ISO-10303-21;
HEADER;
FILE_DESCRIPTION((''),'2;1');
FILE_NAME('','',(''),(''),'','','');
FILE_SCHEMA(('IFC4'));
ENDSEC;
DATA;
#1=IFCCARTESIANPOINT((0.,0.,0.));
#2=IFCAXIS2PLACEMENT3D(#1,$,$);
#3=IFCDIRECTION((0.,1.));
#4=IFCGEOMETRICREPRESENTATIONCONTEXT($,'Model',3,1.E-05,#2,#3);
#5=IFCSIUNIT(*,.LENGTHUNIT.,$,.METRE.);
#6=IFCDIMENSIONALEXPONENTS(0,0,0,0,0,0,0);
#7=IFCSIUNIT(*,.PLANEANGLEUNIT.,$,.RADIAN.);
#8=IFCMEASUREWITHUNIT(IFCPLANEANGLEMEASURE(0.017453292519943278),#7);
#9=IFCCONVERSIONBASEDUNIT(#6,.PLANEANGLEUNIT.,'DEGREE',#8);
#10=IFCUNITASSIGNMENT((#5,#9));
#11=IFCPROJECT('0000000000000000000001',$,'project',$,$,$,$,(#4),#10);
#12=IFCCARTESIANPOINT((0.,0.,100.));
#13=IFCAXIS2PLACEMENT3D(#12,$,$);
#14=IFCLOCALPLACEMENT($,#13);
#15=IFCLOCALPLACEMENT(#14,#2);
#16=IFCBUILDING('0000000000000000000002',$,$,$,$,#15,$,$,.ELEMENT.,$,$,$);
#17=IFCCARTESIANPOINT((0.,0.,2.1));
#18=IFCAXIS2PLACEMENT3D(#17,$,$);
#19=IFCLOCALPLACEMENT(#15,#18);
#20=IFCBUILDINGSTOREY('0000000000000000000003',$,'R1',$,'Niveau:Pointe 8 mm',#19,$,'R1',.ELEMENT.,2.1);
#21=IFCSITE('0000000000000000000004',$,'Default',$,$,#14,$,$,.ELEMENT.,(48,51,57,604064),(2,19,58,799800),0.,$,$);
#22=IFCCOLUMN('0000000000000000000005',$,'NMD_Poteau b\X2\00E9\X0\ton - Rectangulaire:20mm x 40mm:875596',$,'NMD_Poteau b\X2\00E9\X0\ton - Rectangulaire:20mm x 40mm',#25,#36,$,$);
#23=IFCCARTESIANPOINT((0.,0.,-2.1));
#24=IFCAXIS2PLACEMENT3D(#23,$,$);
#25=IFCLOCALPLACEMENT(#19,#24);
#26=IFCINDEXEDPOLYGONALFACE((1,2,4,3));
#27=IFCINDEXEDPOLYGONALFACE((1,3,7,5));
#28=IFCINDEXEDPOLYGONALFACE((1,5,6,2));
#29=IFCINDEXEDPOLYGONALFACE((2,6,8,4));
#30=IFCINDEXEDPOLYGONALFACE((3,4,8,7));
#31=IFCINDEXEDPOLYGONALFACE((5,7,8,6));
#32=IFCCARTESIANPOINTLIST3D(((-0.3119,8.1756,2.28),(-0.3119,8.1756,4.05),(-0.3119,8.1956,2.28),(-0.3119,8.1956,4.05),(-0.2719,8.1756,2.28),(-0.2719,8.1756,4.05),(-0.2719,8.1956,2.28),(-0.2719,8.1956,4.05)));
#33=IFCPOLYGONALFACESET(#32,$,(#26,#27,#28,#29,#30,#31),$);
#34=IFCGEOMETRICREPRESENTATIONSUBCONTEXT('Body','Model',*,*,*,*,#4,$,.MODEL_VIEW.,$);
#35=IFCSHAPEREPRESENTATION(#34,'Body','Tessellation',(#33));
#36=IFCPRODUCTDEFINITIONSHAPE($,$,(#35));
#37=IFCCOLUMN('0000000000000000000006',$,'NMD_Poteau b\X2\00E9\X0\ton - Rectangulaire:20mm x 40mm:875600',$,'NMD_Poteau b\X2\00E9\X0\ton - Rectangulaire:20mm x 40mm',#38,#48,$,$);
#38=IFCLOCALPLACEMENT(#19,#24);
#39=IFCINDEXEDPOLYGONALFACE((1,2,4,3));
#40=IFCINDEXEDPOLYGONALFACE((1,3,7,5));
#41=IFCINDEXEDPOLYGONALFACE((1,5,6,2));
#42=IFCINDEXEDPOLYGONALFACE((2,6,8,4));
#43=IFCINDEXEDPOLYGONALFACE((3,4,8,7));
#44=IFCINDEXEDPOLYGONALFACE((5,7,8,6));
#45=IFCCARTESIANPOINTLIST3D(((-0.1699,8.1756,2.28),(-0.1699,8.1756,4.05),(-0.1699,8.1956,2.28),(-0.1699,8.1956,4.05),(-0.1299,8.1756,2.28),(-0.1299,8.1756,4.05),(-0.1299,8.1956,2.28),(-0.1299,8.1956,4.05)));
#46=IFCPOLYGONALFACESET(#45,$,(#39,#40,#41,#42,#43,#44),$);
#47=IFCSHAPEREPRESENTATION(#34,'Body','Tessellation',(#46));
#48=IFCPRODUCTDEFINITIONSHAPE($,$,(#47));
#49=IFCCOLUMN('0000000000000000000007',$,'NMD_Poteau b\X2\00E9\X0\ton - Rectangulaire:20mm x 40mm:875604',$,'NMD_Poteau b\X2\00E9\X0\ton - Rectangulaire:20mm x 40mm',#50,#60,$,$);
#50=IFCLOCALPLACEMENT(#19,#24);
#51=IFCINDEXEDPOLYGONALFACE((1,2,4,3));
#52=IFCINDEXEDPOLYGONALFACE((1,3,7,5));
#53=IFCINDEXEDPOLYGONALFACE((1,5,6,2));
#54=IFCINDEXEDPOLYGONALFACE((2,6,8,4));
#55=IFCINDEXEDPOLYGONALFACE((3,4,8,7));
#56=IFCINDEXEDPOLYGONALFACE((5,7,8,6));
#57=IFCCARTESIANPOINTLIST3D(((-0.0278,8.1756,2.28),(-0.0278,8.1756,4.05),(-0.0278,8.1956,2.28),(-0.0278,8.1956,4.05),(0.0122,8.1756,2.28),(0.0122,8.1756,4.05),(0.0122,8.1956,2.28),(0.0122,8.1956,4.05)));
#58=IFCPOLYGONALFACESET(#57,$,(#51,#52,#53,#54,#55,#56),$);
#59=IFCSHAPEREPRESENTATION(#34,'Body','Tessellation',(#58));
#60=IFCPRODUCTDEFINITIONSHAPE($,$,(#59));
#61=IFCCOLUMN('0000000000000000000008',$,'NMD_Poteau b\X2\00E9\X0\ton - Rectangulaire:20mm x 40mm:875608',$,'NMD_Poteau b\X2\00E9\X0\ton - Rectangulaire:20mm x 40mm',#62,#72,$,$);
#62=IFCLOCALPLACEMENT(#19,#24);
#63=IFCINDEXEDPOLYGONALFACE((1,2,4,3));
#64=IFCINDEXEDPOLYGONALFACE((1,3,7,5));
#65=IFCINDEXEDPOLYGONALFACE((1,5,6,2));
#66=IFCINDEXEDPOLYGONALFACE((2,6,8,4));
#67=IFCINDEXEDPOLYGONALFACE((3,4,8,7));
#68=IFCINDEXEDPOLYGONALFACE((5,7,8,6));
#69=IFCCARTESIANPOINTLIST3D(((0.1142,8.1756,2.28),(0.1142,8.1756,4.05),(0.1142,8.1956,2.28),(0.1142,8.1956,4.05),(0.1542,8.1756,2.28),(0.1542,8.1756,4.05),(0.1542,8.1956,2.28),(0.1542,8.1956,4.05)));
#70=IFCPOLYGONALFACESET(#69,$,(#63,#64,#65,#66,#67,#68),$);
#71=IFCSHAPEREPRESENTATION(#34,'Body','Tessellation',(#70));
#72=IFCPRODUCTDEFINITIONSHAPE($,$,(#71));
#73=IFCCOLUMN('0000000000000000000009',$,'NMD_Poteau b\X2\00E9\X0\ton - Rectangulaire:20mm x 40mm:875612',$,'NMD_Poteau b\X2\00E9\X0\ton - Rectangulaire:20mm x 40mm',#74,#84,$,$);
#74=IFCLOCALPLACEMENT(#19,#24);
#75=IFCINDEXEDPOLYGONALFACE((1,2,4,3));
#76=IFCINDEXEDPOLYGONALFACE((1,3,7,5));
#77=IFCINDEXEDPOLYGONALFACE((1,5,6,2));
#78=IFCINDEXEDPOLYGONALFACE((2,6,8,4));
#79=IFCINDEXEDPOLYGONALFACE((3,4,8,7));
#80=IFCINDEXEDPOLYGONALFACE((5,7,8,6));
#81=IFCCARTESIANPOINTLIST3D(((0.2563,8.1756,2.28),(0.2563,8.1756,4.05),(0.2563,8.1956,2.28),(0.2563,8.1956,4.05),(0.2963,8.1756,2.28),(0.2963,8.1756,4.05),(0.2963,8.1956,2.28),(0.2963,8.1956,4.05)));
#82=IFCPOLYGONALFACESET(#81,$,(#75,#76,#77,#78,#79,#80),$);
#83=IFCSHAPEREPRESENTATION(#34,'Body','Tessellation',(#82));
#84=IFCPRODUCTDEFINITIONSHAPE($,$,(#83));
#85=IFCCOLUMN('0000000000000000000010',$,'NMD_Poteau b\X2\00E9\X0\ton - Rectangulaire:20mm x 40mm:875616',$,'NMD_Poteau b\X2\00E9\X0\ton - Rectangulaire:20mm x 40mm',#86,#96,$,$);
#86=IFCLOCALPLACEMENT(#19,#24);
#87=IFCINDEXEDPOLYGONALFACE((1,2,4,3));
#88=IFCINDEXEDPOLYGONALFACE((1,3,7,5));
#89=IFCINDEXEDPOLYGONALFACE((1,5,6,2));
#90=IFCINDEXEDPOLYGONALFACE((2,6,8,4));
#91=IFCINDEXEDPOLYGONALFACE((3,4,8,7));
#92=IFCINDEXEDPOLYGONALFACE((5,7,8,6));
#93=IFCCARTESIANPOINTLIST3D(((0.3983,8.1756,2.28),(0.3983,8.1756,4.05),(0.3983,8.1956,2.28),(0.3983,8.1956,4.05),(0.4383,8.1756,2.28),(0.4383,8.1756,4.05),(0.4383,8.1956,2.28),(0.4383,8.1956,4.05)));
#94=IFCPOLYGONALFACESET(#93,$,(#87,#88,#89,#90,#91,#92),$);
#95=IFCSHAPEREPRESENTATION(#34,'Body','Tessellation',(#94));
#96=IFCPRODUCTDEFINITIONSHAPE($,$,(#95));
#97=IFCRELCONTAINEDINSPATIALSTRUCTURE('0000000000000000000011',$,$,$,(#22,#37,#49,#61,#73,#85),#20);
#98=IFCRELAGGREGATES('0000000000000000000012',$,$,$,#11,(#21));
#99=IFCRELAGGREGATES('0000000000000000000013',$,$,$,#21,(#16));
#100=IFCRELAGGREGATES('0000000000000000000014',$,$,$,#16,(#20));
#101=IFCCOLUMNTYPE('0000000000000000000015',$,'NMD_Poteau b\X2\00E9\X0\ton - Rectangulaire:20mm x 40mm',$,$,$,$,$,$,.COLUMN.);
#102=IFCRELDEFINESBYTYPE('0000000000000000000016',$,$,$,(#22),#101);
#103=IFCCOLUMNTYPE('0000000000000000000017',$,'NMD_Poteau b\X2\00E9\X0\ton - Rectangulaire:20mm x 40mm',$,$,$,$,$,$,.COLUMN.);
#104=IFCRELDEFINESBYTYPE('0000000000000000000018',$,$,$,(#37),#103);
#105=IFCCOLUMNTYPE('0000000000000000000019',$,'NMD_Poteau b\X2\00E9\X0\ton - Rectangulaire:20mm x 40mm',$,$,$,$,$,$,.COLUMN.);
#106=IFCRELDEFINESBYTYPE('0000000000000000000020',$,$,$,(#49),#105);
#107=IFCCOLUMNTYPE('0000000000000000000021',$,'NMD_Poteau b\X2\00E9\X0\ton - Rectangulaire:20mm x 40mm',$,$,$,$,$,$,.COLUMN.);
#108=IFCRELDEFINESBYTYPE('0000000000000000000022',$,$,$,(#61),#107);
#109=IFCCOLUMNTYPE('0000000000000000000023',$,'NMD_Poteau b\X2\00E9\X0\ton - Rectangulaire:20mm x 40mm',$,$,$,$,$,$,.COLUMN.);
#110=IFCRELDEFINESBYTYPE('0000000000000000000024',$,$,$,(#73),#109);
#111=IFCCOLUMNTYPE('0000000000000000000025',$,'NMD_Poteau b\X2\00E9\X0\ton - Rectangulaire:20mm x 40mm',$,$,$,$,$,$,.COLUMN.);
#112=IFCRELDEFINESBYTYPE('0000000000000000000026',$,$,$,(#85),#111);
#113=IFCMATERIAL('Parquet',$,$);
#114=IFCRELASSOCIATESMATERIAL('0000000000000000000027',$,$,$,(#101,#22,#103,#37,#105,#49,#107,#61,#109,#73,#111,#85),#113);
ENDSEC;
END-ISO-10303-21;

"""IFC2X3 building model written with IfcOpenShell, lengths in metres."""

from ifc_helpers import new_model, entity, si_unit, converted_unit, direction, frame, frame_2d, origin, origin_2d_with_axis, place, context, subcontext, project, spatial, rectangle, extrude, source, transform, mapped, material, type_object, type_shapes, element, save


model = new_model("IFC2X3")

# Units and contexts
model_context = context("Model", 3, precision=1e-05, world=origin(), true_north=direction((0.0, 1.0)))
body_context = subcontext(model_context, "Body", "Model", "MODEL_VIEW")
ifc_project = project(units=[si_unit("LENGTHUNIT", "METRE"), converted_unit("PLANEANGLEUNIT", "DEGREE", entity("IfcPlaneAngleMeasure", 0.017453292519943278), si_unit("PLANEANGLEUNIT", "RADIAN"), dimensions=[0, 0, 0, 0, 0, 0, 0])], contexts=[model_context])

# Site, building, storey
site_placement = place(None, frame((0.0, 0.0, 100.0)))
site = spatial("IfcSite", under=ifc_project, at=site_placement, Name="Default", CompositionType="ELEMENT", RefLatitude=(48, 51, 57, 604064), RefLongitude=(2, 19, 58, 799800), RefElevation=0.0)
building_placement = place(site_placement, origin())
building = spatial("IfcBuilding", under=site, at=building_placement, CompositionType="ELEMENT")
storey_placement = place(building_placement, frame((0.0, 0.0, 2.1)))
storey = spatial("IfcBuildingStorey", under=building, at=storey_placement, Name="R1", ObjectType="Niveau:Pointe 8 mm", LongName="R1", CompositionType="ELEMENT", Elevation=2.1)

# Columns
ifc_material_1 = material(Name="Parquet")
column_type_1 = type_object("IfcColumnType", Name="NMD_Poteau béton - Rectangulaire:20mm x 40mm", PredefinedType="COLUMN", material=ifc_material_1)
shared_shape_1 = source(origin(), body_context, "Body", "SweptSolid", [
    extrude(rectangle(XDim=0.02, YDim=0.04, at=frame_2d((0.0, 0.0), x_axis=(1.0, 0.0))), frame((-0.2919, 8.1856, 2.28), z_axis=(0.0, 0.0, 1.0), x_axis=(0.0, -1.0, 0.0)), (0.0, 0.0, 1.0), 1.77),
])
type_shapes(column_type_1, [shared_shape_1])
column_1_placement = place(storey_placement, frame((0.0, 0.0, -2.1)))
element("IfcColumn", 1, at=column_1_placement, inside=storey, type_object=column_type_1, material=ifc_material_1, Name="NMD_Poteau béton - Rectangulaire:20mm x 40mm:875596", ObjectType="NMD_Poteau béton - Rectangulaire:20mm x 40mm", context=body_context, shape_type="MappedRepresentation", body=[
    mapped(shared_shape_1, transform((0.0, 0.0, 0.0), scale=1.0)),
])
column_type_2 = type_object("IfcColumnType", Name="NMD_Poteau béton - Rectangulaire:20mm x 40mm", PredefinedType="COLUMN", material=ifc_material_1)
shared_shape_2 = source(origin(), body_context, "Body", "SweptSolid", [
    extrude(rectangle(XDim=0.02, YDim=0.04, at=frame_2d((0.0, 0.0), x_axis=(1.0, 0.0))), frame((-0.1499, 8.1856, 2.28), z_axis=(0.0, 0.0, 1.0), x_axis=(0.0, -1.0, 0.0)), (0.0, 0.0, 1.0), 1.77),
])
type_shapes(column_type_2, [shared_shape_2])
column_2_placement = place(storey_placement, frame((0.0, 0.0, -2.1)))
element("IfcColumn", 2, at=column_2_placement, inside=storey, type_object=column_type_2, material=ifc_material_1, Name="NMD_Poteau béton - Rectangulaire:20mm x 40mm:875600", ObjectType="NMD_Poteau béton - Rectangulaire:20mm x 40mm", context=body_context, shape_type="MappedRepresentation", body=[
    mapped(shared_shape_2, transform((0.0, 0.0, 0.0), scale=1.0)),
])
column_type_3 = type_object("IfcColumnType", Name="NMD_Poteau béton - Rectangulaire:20mm x 40mm", PredefinedType="COLUMN", material=ifc_material_1)
shared_shape_3 = source(origin(), body_context, "Body", "SweptSolid", [
    extrude(rectangle(XDim=0.02, YDim=0.04, at=origin_2d_with_axis()), frame((-0.0078, 8.1856, 2.28), z_axis=(0.0, 0.0, 1.0), x_axis=(0.0, -1.0, 0.0)), (0.0, 0.0, 1.0), 1.77),
])
type_shapes(column_type_3, [shared_shape_3])
column_3_placement = place(storey_placement, frame((0.0, 0.0, -2.1)))
element("IfcColumn", 3, at=column_3_placement, inside=storey, type_object=column_type_3, material=ifc_material_1, Name="NMD_Poteau béton - Rectangulaire:20mm x 40mm:875604", ObjectType="NMD_Poteau béton - Rectangulaire:20mm x 40mm", context=body_context, shape_type="MappedRepresentation", body=[
    mapped(shared_shape_3, transform((0.0, 0.0, 0.0), scale=1.0)),
])
column_type_4 = type_object("IfcColumnType", Name="NMD_Poteau béton - Rectangulaire:20mm x 40mm", PredefinedType="COLUMN", material=ifc_material_1)
shared_shape_4 = source(origin(), body_context, "Body", "SweptSolid", [
    extrude(rectangle(XDim=0.02, YDim=0.04, at=frame_2d((0.0, 0.0), x_axis=(1.0, 0.0))), frame((0.1342, 8.1856, 2.28), z_axis=(0.0, 0.0, 1.0), x_axis=(0.0, -1.0, 0.0)), (0.0, 0.0, 1.0), 1.77),
])
type_shapes(column_type_4, [shared_shape_4])
column_4_placement = place(storey_placement, frame((0.0, 0.0, -2.1)))
element("IfcColumn", 4, at=column_4_placement, inside=storey, type_object=column_type_4, material=ifc_material_1, Name="NMD_Poteau béton - Rectangulaire:20mm x 40mm:875608", ObjectType="NMD_Poteau béton - Rectangulaire:20mm x 40mm", context=body_context, shape_type="MappedRepresentation", body=[
    mapped(shared_shape_4, transform((0.0, 0.0, 0.0), scale=1.0)),
])
column_type_5 = type_object("IfcColumnType", Name="NMD_Poteau béton - Rectangulaire:20mm x 40mm", PredefinedType="COLUMN", material=ifc_material_1)
shared_shape_5 = source(origin(), body_context, "Body", "SweptSolid", [
    extrude(rectangle(XDim=0.02, YDim=0.04, at=origin_2d_with_axis()), frame((0.2763, 8.1856, 2.28), z_axis=(0.0, 0.0, 1.0), x_axis=(0.0, -1.0, 0.0)), (0.0, 0.0, 1.0), 1.77),
])
type_shapes(column_type_5, [shared_shape_5])
column_5_placement = place(storey_placement, frame((0.0, 0.0, -2.1)))
element("IfcColumn", 5, at=column_5_placement, inside=storey, type_object=column_type_5, material=ifc_material_1, Name="NMD_Poteau béton - Rectangulaire:20mm x 40mm:875612", ObjectType="NMD_Poteau béton - Rectangulaire:20mm x 40mm", context=body_context, shape_type="MappedRepresentation", body=[
    mapped(shared_shape_5, transform((0.0, 0.0, 0.0), scale=1.0)),
])
column_type_6 = type_object("IfcColumnType", Name="NMD_Poteau béton - Rectangulaire:20mm x 40mm", PredefinedType="COLUMN", material=ifc_material_1)
shared_shape_6 = source(origin(), body_context, "Body", "SweptSolid", [
    extrude(rectangle(XDim=0.02, YDim=0.04, at=frame_2d((0.0, 0.0), x_axis=(1.0, 0.0))), frame((0.4183, 8.1856, 2.28), z_axis=(0.0, 0.0, 1.0), x_axis=(0.0, -1.0, 0.0)), (0.0, 0.0, 1.0), 1.77),
])
type_shapes(column_type_6, [shared_shape_6])
column_6_placement = place(storey_placement, frame((0.0, 0.0, -2.1)))
element("IfcColumn", 6, at=column_6_placement, inside=storey, type_object=column_type_6, material=ifc_material_1, Name="NMD_Poteau béton - Rectangulaire:20mm x 40mm:875616", ObjectType="NMD_Poteau béton - Rectangulaire:20mm x 40mm", context=body_context, shape_type="MappedRepresentation", body=[
    mapped(shared_shape_6, transform((0.0, 0.0, 0.0), scale=1.0)),
])

save(model, "model.ifc")
